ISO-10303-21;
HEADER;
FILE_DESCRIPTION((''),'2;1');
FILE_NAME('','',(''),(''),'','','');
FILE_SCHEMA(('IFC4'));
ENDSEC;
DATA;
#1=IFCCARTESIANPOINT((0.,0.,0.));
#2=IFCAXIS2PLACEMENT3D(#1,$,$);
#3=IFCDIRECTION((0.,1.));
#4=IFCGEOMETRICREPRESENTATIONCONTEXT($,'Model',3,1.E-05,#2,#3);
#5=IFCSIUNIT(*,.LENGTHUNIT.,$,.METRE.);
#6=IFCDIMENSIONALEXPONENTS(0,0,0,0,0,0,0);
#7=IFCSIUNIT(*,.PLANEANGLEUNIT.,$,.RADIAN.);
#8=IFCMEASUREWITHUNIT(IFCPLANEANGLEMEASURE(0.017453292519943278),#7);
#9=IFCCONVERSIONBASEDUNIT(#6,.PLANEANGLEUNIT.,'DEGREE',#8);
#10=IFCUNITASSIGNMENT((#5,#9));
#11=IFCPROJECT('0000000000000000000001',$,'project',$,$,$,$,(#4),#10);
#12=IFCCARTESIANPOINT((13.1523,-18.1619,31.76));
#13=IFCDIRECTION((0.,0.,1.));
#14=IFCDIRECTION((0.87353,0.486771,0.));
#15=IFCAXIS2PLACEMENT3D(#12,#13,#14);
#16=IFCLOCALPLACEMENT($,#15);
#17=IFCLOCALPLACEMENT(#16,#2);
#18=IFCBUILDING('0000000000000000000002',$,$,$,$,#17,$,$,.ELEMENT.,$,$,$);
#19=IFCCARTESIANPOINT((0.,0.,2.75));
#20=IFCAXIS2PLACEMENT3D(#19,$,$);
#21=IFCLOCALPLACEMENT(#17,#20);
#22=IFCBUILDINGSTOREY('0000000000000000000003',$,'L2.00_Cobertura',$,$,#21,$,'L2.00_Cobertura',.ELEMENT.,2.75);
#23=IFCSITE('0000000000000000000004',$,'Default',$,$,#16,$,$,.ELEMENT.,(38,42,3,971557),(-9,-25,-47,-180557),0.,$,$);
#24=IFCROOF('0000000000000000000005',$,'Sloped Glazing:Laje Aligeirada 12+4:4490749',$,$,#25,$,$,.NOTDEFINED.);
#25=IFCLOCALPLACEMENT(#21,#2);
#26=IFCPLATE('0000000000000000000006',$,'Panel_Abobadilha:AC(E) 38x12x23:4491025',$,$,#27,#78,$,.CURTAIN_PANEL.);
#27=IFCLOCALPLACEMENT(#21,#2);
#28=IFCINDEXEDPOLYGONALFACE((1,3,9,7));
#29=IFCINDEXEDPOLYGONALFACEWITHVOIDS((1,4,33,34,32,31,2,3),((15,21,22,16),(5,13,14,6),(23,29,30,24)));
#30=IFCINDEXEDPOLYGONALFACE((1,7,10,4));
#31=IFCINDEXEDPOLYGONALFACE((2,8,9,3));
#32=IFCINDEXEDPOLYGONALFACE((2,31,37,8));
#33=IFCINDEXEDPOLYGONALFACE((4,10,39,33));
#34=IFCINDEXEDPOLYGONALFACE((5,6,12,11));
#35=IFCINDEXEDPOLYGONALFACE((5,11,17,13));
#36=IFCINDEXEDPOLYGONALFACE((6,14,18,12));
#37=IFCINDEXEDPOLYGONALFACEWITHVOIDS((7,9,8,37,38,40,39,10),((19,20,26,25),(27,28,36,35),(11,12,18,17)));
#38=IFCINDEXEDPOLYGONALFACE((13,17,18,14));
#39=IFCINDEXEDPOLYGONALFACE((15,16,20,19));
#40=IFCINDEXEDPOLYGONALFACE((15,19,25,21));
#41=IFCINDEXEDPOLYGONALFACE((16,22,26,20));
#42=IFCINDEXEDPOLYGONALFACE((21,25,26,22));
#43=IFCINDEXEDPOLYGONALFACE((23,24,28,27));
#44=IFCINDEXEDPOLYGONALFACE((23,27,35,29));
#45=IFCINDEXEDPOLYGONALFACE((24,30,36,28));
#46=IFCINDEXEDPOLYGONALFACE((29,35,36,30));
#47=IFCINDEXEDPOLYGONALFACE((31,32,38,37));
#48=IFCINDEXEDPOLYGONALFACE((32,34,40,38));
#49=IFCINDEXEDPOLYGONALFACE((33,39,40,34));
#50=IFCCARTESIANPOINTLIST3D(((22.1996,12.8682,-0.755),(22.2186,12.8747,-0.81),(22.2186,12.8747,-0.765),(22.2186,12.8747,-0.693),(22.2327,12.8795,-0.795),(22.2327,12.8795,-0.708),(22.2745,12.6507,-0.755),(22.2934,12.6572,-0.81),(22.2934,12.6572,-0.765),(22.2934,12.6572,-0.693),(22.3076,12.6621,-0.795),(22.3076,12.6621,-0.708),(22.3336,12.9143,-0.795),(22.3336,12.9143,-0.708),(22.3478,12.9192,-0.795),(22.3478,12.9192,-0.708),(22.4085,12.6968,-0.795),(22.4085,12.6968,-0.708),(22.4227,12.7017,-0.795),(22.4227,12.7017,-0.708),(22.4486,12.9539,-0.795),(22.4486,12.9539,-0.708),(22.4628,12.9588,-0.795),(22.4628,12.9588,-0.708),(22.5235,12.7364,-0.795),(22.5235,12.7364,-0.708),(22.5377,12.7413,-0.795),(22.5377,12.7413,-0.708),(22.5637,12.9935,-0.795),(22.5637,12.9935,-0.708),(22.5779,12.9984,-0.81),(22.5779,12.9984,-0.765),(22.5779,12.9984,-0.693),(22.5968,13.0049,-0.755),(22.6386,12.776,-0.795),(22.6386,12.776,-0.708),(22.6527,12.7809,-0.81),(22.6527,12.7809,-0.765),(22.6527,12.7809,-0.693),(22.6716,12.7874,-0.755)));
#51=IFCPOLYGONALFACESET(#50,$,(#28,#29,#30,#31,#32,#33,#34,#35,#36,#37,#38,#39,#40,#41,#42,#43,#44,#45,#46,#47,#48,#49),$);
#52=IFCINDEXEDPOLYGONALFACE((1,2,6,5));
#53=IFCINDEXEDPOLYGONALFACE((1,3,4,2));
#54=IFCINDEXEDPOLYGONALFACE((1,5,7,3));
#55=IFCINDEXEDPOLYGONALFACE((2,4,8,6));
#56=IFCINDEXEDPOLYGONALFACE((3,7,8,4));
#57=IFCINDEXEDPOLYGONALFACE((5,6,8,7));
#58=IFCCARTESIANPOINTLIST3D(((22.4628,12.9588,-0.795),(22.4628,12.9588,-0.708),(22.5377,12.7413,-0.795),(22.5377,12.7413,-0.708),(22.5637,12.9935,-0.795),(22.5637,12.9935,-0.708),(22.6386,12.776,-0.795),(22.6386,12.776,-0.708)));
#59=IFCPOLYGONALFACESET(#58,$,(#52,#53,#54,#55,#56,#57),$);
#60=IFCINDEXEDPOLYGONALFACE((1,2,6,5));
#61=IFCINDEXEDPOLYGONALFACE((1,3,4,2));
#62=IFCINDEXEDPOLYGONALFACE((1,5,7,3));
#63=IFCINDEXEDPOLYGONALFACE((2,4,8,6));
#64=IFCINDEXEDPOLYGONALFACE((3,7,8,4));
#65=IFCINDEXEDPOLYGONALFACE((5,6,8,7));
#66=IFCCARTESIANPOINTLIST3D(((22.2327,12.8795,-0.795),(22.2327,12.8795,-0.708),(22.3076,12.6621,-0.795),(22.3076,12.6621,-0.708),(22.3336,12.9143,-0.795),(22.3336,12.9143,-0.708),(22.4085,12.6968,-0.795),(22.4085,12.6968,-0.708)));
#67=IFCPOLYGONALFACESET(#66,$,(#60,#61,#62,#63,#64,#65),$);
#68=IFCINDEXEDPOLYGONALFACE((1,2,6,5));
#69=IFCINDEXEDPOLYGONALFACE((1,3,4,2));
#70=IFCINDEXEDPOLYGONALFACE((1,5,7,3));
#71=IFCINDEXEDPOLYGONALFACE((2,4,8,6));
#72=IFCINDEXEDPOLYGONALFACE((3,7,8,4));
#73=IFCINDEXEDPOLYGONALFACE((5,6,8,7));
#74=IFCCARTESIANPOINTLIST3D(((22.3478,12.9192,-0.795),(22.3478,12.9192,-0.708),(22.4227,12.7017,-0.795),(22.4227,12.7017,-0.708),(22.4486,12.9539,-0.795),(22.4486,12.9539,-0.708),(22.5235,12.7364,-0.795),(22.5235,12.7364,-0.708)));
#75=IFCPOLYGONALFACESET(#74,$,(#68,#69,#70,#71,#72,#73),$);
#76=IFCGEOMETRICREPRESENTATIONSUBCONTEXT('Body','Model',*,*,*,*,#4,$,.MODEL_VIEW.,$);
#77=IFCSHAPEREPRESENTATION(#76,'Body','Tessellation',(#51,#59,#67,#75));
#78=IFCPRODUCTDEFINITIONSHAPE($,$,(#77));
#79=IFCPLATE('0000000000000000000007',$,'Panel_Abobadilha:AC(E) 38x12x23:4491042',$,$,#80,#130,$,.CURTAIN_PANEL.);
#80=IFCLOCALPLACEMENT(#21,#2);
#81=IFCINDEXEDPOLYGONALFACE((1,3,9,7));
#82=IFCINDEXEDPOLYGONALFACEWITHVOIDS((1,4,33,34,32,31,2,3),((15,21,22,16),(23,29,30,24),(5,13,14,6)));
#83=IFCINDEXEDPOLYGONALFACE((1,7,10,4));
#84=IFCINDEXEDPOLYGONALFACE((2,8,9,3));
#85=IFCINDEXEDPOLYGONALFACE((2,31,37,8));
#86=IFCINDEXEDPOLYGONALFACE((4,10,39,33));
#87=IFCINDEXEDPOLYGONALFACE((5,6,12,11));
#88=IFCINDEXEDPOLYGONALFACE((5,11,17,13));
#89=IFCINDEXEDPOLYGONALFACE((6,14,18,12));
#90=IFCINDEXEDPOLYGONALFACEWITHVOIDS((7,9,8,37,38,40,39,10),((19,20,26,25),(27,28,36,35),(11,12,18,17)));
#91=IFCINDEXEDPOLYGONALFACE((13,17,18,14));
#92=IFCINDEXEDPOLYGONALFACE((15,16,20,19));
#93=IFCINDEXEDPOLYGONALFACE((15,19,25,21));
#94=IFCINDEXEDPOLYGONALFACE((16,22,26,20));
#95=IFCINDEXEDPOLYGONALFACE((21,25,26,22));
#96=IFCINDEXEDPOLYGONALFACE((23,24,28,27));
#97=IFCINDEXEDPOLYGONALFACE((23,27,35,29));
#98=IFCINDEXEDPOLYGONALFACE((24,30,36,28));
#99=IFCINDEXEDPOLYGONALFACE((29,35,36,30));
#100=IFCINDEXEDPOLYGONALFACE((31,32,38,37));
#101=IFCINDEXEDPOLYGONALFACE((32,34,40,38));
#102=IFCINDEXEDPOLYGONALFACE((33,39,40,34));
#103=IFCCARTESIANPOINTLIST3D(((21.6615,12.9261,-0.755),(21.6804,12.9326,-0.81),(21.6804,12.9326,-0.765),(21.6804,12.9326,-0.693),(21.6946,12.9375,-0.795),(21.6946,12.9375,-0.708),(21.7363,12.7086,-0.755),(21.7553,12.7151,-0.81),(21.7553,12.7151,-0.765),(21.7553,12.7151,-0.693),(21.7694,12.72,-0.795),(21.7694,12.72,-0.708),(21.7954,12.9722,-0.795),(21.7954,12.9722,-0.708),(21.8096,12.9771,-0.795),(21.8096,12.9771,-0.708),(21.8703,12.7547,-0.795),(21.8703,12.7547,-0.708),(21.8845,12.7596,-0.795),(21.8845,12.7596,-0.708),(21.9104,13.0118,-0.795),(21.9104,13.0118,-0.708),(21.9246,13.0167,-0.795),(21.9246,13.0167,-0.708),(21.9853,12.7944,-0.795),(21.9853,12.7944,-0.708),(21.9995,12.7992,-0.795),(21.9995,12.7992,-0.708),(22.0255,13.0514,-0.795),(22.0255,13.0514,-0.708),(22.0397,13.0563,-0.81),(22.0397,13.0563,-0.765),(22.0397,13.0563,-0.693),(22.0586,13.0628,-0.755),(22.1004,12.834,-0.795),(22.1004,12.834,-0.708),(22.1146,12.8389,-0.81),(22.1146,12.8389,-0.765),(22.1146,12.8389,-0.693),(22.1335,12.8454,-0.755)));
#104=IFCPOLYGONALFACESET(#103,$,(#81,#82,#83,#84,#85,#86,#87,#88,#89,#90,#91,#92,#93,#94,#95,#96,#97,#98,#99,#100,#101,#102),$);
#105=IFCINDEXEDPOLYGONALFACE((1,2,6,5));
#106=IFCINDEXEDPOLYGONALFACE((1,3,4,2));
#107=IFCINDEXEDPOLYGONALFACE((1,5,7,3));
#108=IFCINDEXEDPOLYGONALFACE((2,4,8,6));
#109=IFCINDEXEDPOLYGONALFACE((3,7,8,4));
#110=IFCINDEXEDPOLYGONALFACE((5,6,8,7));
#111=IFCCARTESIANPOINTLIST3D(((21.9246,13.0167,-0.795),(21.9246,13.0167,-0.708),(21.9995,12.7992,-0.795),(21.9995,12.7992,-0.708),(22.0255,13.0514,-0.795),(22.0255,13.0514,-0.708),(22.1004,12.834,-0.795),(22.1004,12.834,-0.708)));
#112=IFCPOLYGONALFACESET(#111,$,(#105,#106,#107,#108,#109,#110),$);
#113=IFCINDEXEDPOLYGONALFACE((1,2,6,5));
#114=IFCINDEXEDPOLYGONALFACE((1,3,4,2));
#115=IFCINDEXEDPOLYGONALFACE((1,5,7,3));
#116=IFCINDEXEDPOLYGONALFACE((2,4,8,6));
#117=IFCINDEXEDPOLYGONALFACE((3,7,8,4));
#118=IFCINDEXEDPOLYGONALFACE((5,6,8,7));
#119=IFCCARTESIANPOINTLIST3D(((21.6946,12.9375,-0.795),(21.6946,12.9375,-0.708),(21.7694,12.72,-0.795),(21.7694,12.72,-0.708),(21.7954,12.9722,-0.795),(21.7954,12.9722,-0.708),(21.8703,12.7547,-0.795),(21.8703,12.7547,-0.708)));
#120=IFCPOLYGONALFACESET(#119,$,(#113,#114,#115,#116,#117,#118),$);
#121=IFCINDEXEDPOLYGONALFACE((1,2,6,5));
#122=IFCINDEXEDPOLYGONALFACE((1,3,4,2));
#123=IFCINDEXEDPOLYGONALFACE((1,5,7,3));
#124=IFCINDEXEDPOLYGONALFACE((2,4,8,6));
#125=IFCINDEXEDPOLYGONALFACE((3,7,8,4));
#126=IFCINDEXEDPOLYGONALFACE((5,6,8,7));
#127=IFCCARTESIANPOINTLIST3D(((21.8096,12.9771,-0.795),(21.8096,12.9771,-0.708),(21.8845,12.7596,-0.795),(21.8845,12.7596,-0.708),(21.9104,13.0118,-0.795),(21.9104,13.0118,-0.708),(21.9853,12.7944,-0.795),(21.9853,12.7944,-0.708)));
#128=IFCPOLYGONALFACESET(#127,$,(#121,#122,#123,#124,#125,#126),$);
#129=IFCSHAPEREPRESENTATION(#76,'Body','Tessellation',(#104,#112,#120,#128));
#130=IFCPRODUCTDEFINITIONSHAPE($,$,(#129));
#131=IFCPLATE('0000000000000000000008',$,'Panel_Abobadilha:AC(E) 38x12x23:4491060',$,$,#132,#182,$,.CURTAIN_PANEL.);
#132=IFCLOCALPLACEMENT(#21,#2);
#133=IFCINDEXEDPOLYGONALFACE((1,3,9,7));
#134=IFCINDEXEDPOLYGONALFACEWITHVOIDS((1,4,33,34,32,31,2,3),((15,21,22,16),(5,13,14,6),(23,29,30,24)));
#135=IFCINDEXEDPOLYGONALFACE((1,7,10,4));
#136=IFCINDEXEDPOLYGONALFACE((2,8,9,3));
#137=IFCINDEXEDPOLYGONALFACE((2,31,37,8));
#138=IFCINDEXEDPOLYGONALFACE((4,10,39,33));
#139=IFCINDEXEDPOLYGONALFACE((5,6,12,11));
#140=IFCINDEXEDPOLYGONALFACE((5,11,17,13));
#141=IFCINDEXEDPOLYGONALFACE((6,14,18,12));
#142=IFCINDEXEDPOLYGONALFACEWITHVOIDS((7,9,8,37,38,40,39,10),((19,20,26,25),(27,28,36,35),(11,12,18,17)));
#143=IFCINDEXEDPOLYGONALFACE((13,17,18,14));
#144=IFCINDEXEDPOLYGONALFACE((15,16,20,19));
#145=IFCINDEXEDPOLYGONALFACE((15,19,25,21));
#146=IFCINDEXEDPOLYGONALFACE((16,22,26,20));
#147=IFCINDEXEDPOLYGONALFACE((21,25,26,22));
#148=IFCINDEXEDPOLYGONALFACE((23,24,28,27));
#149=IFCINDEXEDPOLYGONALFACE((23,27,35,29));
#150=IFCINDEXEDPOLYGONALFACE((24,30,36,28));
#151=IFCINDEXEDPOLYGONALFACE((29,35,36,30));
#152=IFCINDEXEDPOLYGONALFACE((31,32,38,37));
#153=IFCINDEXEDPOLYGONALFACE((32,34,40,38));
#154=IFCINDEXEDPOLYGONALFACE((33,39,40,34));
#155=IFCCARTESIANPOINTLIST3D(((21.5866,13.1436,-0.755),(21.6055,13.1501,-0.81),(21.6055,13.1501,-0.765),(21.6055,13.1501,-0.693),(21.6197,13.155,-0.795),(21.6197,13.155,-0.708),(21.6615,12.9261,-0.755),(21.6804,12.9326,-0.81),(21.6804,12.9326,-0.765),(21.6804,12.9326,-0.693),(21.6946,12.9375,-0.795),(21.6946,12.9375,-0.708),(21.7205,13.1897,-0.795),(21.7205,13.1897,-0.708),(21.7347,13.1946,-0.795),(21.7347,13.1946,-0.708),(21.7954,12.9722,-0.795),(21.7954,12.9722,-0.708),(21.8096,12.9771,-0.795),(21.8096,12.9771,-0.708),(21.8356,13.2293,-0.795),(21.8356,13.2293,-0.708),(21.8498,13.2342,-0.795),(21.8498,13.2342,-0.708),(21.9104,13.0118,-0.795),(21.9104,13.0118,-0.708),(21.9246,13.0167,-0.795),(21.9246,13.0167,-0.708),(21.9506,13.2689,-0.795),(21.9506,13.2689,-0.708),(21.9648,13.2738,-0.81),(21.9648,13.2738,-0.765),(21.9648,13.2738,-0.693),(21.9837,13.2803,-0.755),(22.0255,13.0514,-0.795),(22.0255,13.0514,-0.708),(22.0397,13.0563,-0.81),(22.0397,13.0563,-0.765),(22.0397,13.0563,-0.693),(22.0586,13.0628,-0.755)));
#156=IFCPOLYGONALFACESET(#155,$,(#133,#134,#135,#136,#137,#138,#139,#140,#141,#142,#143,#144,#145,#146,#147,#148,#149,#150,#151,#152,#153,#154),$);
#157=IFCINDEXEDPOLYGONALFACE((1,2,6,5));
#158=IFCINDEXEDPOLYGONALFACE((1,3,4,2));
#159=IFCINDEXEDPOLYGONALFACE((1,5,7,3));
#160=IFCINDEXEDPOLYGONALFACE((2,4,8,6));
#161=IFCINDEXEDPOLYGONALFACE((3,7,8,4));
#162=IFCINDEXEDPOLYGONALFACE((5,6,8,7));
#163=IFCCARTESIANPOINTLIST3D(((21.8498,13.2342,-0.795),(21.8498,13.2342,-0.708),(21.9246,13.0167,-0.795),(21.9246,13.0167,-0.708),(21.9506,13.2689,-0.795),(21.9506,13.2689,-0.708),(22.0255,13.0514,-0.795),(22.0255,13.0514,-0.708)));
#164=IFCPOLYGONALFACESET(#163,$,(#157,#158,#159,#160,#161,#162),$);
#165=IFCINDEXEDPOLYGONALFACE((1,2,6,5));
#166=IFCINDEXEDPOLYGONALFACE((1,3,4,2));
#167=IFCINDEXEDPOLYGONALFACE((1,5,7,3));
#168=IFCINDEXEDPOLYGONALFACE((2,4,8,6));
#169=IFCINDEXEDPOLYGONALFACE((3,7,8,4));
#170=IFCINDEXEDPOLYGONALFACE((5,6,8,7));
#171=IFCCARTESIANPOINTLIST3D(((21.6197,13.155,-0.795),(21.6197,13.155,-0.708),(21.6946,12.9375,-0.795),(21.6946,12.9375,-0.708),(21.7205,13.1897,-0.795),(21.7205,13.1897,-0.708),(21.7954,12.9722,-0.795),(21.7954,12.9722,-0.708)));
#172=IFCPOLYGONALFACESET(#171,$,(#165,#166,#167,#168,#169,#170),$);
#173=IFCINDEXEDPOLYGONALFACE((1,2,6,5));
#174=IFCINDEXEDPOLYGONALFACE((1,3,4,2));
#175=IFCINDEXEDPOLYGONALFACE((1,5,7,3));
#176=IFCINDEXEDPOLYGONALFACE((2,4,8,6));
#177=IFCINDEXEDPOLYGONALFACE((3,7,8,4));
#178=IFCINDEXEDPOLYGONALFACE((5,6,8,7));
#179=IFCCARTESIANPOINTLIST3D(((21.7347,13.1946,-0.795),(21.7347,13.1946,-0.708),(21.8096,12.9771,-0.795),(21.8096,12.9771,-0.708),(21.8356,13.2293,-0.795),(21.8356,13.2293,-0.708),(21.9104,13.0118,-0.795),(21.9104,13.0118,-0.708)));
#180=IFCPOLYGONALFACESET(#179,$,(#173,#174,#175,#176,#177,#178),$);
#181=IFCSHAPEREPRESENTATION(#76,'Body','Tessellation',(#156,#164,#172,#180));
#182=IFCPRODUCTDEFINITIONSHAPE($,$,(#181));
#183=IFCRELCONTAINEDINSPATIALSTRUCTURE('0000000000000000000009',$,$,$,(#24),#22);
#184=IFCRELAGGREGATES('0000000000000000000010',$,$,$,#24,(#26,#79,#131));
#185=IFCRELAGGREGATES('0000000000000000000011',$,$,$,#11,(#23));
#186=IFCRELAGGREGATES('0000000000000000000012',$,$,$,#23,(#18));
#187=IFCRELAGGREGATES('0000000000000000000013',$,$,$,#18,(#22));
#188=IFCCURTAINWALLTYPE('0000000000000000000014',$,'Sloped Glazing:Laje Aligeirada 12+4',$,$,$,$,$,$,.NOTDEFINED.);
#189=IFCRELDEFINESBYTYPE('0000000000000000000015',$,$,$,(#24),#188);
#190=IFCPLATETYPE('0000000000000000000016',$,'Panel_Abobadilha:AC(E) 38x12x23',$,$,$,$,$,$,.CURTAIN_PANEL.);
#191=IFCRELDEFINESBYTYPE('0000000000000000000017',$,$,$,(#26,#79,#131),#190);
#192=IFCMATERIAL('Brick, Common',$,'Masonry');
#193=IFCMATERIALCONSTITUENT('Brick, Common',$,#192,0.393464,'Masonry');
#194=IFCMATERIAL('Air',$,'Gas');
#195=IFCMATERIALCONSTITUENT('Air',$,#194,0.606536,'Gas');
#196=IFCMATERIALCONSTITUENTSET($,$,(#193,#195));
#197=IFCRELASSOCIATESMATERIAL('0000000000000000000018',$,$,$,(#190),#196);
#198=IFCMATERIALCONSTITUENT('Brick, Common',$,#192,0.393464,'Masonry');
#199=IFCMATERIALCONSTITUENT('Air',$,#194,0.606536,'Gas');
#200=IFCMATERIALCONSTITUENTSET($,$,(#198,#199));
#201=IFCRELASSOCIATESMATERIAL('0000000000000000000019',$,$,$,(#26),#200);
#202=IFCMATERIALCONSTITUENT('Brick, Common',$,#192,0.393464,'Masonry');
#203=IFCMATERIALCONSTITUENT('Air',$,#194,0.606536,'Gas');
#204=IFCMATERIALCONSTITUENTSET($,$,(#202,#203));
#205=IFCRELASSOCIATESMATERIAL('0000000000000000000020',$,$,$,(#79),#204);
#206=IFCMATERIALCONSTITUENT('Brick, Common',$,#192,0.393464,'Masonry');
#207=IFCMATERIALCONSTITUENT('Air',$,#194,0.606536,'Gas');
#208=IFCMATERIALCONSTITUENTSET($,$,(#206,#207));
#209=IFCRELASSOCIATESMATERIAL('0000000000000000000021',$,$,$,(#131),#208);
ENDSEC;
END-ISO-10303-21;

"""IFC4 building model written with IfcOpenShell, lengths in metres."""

from ifc_helpers import new_model, entity, si_unit, converted_unit, direction, frame, origin, place, context, subcontext, project, spatial, indexed_curve, outline, extrude, source, transform, mapped, material, constituent, constituent_set, type_object, type_shapes, element, aggregate, save


model = new_model("IFC4")

# Units and contexts
model_context = context("Model", 3, precision=1e-05, world=origin(), true_north=direction((0.0, 1.0)))
body_context = subcontext(model_context, "Body", "Model", "MODEL_VIEW")
ifc_project = project(units=[si_unit("LENGTHUNIT", "METRE"), converted_unit("PLANEANGLEUNIT", "DEGREE", entity("IfcPlaneAngleMeasure", 0.017453292519943278), si_unit("PLANEANGLEUNIT", "RADIAN"), dimensions=[0, 0, 0, 0, 0, 0, 0])], contexts=[model_context])

# Site, building, storey
site_placement = place(None, frame((13.1523, -18.1619, 31.76), z_axis=(0.0, 0.0, 1.0), x_axis=(0.87353, 0.486771, 0.0)))
site = spatial("IfcSite", under=ifc_project, at=site_placement, Name="Default", CompositionType="ELEMENT", RefLatitude=(38, 42, 3, 971557), RefLongitude=(-9, -25, -47, -180557), RefElevation=0.0)
building_placement = place(site_placement, origin())
building = spatial("IfcBuilding", under=site, at=building_placement, CompositionType="ELEMENT")
storey_placement = place(building_placement, frame((0.0, 0.0, 2.75)))
storey = spatial("IfcBuildingStorey", under=building, at=storey_placement, Name="L2.00_Cobertura", LongName="L2.00_Cobertura", CompositionType="ELEMENT", Elevation=2.75)

# Roof, plates
curtain_wall_type = type_object("IfcCurtainWallType", Name="Sloped Glazing:Laje Aligeirada 12+4", PredefinedType="NOTDEFINED")
roof_placement = place(storey_placement, frame((0.0, 0.0, -2.75)))
roof = element("IfcRoof", 1, at=roof_placement, inside=storey, type_object=curtain_wall_type, Name="Sloped Glazing:Laje Aligeirada 12+4:4490749", PredefinedType="NOTDEFINED")
ifc_material_1 = material(Name="Brick, Common", Category="Masonry")
ifc_material_2 = material(Name="Air", Category="Gas")
ifc_constituent_1 = constituent(ifc_material_1, Name="Brick, Common", Category="Masonry", fraction=0.393464)
ifc_constituent_2 = constituent(ifc_material_2, Name="Air", Category="Gas", fraction=0.606536)
ifc_constituent_set_1 = constituent_set(constituents=[ifc_constituent_1, ifc_constituent_2])
plate_type = type_object("IfcPlateType", Name="Panel_Abobadilha:AC(E) 38x12x23", PredefinedType="CURTAIN_PANEL", material=ifc_constituent_set_1)
shared_shape_1 = source(origin(), body_context, "Body", "SweptSolid", [
    extrude(outline(indexed_curve([(-0.19, -0.0543), (0.19, -0.0543), (0.19, -0.0093), (0.21, 0.0007), (0.19, 0.0628), (-0.19, 0.0628), (-0.21, 0.0007), (-0.19, -0.0093), (-0.19, -0.0543)], self_intersect=False), holes=[indexed_curve([(-0.0683, 0.0477), (-0.0683, -0.0393), (-0.175, -0.0393), (-0.175, 0.0477), (-0.0683, 0.0477)], self_intersect=False), indexed_curve([(0.0533, 0.0477), (0.0533, -0.0393), (-0.0533, -0.0393), (-0.0533, 0.0477), (0.0533, 0.0477)], self_intersect=False), indexed_curve([(0.175, 0.0477), (0.175, -0.0393), (0.0683, -0.0393), (0.0683, 0.0477), (0.175, 0.0477)], self_intersect=False)]), frame((0.0, 0.0543, 0.0)), (0.0, 0.0, 1.0), 0.23),
    extrude(outline(indexed_curve([(-0.0533, -0.0435), (0.0533, -0.0435), (0.0533, 0.0435), (-0.0533, 0.0435), (-0.0533, -0.0435)], self_intersect=False)), frame((0.1217, 0.0585, 0.0), z_axis=(0.0, 0.0, 1.0), x_axis=(-1.0, 0.0, 0.0)), (0.0, 0.0, 1.0), 0.23),
    extrude(outline(indexed_curve([(-0.0533, -0.0435), (0.0533, -0.0435), (0.0533, 0.0435), (-0.0533, 0.0435), (-0.0533, -0.0435)], self_intersect=False)), frame((-0.1217, 0.0585, 0.0), z_axis=(0.0, 0.0, 1.0), x_axis=(-1.0, 0.0, 0.0)), (0.0, 0.0, 1.0), 0.23),
    extrude(outline(indexed_curve([(-0.0533, -0.0435), (0.0533, -0.0435), (0.0533, 0.0435), (-0.0533, 0.0435), (-0.0533, -0.0435)], self_intersect=False)), frame((0.0, 0.0585, 0.0), z_axis=(0.0, 0.0, 1.0), x_axis=(-1.0, 0.0, 0.0)), (0.0, 0.0, 1.0), 0.23),
])
type_shapes(plate_type, [shared_shape_1])
ifc_constituent_3 = constituent(ifc_material_1, Name="Brick, Common", Category="Masonry", fraction=0.393464)
ifc_constituent_4 = constituent(ifc_material_2, Name="Air", Category="Gas", fraction=0.606536)
ifc_constituent_set_2 = constituent_set(constituents=[ifc_constituent_3, ifc_constituent_4])
plate_1_placement = place(roof_placement, frame((22.3982, 12.9365, 1.94), z_axis=(0.325568, -0.945519, 0.0), x_axis=(0.945519, 0.325568, 0.0)))
plate_1 = element("IfcPlate", 2, at=plate_1_placement, type_object=plate_type, material=ifc_constituent_set_2, Name="Panel_Abobadilha:AC(E) 38x12x23:4491025", PredefinedType="CURTAIN_PANEL", context=body_context, shape_type="MappedRepresentation", body=[
    mapped(shared_shape_1, transform((0.0, 0.0, 0.0), scale=1.0)),
])
ifc_constituent_5 = constituent(ifc_material_1, Name="Brick, Common", Category="Masonry", fraction=0.393464)
ifc_constituent_6 = constituent(ifc_material_2, Name="Air", Category="Gas", fraction=0.606536)
ifc_constituent_set_3 = constituent_set(constituents=[ifc_constituent_5, ifc_constituent_6])
plate_2_placement = place(roof_placement, frame((21.86, 12.9945, 1.94), z_axis=(0.325568, -0.945519, 0.0), x_axis=(0.945519, 0.325568, 0.0)))
plate_2 = element("IfcPlate", 3, at=plate_2_placement, type_object=plate_type, material=ifc_constituent_set_3, Name="Panel_Abobadilha:AC(E) 38x12x23:4491042", PredefinedType="CURTAIN_PANEL", context=body_context, shape_type="MappedRepresentation", body=[
    mapped(shared_shape_1, transform((0.0, 0.0, 0.0), scale=1.0)),
])
ifc_constituent_7 = constituent(ifc_material_1, Name="Brick, Common", Category="Masonry", fraction=0.393464)
ifc_constituent_8 = constituent(ifc_material_2, Name="Air", Category="Gas", fraction=0.606536)
ifc_constituent_set_4 = constituent_set(constituents=[ifc_constituent_7, ifc_constituent_8])
plate_3_placement = place(roof_placement, frame((21.7851, 13.2119, 1.94), z_axis=(0.325568, -0.945519, 0.0), x_axis=(0.945519, 0.325568, 0.0)))
plate_3 = element("IfcPlate", 4, at=plate_3_placement, type_object=plate_type, material=ifc_constituent_set_4, Name="Panel_Abobadilha:AC(E) 38x12x23:4491060", PredefinedType="CURTAIN_PANEL", context=body_context, shape_type="MappedRepresentation", body=[
    mapped(shared_shape_1, transform((0.0, 0.0, 0.0), scale=1.0)),
])
aggregate(roof, [plate_1, plate_2, plate_3])

save(model, "model.ifc")
